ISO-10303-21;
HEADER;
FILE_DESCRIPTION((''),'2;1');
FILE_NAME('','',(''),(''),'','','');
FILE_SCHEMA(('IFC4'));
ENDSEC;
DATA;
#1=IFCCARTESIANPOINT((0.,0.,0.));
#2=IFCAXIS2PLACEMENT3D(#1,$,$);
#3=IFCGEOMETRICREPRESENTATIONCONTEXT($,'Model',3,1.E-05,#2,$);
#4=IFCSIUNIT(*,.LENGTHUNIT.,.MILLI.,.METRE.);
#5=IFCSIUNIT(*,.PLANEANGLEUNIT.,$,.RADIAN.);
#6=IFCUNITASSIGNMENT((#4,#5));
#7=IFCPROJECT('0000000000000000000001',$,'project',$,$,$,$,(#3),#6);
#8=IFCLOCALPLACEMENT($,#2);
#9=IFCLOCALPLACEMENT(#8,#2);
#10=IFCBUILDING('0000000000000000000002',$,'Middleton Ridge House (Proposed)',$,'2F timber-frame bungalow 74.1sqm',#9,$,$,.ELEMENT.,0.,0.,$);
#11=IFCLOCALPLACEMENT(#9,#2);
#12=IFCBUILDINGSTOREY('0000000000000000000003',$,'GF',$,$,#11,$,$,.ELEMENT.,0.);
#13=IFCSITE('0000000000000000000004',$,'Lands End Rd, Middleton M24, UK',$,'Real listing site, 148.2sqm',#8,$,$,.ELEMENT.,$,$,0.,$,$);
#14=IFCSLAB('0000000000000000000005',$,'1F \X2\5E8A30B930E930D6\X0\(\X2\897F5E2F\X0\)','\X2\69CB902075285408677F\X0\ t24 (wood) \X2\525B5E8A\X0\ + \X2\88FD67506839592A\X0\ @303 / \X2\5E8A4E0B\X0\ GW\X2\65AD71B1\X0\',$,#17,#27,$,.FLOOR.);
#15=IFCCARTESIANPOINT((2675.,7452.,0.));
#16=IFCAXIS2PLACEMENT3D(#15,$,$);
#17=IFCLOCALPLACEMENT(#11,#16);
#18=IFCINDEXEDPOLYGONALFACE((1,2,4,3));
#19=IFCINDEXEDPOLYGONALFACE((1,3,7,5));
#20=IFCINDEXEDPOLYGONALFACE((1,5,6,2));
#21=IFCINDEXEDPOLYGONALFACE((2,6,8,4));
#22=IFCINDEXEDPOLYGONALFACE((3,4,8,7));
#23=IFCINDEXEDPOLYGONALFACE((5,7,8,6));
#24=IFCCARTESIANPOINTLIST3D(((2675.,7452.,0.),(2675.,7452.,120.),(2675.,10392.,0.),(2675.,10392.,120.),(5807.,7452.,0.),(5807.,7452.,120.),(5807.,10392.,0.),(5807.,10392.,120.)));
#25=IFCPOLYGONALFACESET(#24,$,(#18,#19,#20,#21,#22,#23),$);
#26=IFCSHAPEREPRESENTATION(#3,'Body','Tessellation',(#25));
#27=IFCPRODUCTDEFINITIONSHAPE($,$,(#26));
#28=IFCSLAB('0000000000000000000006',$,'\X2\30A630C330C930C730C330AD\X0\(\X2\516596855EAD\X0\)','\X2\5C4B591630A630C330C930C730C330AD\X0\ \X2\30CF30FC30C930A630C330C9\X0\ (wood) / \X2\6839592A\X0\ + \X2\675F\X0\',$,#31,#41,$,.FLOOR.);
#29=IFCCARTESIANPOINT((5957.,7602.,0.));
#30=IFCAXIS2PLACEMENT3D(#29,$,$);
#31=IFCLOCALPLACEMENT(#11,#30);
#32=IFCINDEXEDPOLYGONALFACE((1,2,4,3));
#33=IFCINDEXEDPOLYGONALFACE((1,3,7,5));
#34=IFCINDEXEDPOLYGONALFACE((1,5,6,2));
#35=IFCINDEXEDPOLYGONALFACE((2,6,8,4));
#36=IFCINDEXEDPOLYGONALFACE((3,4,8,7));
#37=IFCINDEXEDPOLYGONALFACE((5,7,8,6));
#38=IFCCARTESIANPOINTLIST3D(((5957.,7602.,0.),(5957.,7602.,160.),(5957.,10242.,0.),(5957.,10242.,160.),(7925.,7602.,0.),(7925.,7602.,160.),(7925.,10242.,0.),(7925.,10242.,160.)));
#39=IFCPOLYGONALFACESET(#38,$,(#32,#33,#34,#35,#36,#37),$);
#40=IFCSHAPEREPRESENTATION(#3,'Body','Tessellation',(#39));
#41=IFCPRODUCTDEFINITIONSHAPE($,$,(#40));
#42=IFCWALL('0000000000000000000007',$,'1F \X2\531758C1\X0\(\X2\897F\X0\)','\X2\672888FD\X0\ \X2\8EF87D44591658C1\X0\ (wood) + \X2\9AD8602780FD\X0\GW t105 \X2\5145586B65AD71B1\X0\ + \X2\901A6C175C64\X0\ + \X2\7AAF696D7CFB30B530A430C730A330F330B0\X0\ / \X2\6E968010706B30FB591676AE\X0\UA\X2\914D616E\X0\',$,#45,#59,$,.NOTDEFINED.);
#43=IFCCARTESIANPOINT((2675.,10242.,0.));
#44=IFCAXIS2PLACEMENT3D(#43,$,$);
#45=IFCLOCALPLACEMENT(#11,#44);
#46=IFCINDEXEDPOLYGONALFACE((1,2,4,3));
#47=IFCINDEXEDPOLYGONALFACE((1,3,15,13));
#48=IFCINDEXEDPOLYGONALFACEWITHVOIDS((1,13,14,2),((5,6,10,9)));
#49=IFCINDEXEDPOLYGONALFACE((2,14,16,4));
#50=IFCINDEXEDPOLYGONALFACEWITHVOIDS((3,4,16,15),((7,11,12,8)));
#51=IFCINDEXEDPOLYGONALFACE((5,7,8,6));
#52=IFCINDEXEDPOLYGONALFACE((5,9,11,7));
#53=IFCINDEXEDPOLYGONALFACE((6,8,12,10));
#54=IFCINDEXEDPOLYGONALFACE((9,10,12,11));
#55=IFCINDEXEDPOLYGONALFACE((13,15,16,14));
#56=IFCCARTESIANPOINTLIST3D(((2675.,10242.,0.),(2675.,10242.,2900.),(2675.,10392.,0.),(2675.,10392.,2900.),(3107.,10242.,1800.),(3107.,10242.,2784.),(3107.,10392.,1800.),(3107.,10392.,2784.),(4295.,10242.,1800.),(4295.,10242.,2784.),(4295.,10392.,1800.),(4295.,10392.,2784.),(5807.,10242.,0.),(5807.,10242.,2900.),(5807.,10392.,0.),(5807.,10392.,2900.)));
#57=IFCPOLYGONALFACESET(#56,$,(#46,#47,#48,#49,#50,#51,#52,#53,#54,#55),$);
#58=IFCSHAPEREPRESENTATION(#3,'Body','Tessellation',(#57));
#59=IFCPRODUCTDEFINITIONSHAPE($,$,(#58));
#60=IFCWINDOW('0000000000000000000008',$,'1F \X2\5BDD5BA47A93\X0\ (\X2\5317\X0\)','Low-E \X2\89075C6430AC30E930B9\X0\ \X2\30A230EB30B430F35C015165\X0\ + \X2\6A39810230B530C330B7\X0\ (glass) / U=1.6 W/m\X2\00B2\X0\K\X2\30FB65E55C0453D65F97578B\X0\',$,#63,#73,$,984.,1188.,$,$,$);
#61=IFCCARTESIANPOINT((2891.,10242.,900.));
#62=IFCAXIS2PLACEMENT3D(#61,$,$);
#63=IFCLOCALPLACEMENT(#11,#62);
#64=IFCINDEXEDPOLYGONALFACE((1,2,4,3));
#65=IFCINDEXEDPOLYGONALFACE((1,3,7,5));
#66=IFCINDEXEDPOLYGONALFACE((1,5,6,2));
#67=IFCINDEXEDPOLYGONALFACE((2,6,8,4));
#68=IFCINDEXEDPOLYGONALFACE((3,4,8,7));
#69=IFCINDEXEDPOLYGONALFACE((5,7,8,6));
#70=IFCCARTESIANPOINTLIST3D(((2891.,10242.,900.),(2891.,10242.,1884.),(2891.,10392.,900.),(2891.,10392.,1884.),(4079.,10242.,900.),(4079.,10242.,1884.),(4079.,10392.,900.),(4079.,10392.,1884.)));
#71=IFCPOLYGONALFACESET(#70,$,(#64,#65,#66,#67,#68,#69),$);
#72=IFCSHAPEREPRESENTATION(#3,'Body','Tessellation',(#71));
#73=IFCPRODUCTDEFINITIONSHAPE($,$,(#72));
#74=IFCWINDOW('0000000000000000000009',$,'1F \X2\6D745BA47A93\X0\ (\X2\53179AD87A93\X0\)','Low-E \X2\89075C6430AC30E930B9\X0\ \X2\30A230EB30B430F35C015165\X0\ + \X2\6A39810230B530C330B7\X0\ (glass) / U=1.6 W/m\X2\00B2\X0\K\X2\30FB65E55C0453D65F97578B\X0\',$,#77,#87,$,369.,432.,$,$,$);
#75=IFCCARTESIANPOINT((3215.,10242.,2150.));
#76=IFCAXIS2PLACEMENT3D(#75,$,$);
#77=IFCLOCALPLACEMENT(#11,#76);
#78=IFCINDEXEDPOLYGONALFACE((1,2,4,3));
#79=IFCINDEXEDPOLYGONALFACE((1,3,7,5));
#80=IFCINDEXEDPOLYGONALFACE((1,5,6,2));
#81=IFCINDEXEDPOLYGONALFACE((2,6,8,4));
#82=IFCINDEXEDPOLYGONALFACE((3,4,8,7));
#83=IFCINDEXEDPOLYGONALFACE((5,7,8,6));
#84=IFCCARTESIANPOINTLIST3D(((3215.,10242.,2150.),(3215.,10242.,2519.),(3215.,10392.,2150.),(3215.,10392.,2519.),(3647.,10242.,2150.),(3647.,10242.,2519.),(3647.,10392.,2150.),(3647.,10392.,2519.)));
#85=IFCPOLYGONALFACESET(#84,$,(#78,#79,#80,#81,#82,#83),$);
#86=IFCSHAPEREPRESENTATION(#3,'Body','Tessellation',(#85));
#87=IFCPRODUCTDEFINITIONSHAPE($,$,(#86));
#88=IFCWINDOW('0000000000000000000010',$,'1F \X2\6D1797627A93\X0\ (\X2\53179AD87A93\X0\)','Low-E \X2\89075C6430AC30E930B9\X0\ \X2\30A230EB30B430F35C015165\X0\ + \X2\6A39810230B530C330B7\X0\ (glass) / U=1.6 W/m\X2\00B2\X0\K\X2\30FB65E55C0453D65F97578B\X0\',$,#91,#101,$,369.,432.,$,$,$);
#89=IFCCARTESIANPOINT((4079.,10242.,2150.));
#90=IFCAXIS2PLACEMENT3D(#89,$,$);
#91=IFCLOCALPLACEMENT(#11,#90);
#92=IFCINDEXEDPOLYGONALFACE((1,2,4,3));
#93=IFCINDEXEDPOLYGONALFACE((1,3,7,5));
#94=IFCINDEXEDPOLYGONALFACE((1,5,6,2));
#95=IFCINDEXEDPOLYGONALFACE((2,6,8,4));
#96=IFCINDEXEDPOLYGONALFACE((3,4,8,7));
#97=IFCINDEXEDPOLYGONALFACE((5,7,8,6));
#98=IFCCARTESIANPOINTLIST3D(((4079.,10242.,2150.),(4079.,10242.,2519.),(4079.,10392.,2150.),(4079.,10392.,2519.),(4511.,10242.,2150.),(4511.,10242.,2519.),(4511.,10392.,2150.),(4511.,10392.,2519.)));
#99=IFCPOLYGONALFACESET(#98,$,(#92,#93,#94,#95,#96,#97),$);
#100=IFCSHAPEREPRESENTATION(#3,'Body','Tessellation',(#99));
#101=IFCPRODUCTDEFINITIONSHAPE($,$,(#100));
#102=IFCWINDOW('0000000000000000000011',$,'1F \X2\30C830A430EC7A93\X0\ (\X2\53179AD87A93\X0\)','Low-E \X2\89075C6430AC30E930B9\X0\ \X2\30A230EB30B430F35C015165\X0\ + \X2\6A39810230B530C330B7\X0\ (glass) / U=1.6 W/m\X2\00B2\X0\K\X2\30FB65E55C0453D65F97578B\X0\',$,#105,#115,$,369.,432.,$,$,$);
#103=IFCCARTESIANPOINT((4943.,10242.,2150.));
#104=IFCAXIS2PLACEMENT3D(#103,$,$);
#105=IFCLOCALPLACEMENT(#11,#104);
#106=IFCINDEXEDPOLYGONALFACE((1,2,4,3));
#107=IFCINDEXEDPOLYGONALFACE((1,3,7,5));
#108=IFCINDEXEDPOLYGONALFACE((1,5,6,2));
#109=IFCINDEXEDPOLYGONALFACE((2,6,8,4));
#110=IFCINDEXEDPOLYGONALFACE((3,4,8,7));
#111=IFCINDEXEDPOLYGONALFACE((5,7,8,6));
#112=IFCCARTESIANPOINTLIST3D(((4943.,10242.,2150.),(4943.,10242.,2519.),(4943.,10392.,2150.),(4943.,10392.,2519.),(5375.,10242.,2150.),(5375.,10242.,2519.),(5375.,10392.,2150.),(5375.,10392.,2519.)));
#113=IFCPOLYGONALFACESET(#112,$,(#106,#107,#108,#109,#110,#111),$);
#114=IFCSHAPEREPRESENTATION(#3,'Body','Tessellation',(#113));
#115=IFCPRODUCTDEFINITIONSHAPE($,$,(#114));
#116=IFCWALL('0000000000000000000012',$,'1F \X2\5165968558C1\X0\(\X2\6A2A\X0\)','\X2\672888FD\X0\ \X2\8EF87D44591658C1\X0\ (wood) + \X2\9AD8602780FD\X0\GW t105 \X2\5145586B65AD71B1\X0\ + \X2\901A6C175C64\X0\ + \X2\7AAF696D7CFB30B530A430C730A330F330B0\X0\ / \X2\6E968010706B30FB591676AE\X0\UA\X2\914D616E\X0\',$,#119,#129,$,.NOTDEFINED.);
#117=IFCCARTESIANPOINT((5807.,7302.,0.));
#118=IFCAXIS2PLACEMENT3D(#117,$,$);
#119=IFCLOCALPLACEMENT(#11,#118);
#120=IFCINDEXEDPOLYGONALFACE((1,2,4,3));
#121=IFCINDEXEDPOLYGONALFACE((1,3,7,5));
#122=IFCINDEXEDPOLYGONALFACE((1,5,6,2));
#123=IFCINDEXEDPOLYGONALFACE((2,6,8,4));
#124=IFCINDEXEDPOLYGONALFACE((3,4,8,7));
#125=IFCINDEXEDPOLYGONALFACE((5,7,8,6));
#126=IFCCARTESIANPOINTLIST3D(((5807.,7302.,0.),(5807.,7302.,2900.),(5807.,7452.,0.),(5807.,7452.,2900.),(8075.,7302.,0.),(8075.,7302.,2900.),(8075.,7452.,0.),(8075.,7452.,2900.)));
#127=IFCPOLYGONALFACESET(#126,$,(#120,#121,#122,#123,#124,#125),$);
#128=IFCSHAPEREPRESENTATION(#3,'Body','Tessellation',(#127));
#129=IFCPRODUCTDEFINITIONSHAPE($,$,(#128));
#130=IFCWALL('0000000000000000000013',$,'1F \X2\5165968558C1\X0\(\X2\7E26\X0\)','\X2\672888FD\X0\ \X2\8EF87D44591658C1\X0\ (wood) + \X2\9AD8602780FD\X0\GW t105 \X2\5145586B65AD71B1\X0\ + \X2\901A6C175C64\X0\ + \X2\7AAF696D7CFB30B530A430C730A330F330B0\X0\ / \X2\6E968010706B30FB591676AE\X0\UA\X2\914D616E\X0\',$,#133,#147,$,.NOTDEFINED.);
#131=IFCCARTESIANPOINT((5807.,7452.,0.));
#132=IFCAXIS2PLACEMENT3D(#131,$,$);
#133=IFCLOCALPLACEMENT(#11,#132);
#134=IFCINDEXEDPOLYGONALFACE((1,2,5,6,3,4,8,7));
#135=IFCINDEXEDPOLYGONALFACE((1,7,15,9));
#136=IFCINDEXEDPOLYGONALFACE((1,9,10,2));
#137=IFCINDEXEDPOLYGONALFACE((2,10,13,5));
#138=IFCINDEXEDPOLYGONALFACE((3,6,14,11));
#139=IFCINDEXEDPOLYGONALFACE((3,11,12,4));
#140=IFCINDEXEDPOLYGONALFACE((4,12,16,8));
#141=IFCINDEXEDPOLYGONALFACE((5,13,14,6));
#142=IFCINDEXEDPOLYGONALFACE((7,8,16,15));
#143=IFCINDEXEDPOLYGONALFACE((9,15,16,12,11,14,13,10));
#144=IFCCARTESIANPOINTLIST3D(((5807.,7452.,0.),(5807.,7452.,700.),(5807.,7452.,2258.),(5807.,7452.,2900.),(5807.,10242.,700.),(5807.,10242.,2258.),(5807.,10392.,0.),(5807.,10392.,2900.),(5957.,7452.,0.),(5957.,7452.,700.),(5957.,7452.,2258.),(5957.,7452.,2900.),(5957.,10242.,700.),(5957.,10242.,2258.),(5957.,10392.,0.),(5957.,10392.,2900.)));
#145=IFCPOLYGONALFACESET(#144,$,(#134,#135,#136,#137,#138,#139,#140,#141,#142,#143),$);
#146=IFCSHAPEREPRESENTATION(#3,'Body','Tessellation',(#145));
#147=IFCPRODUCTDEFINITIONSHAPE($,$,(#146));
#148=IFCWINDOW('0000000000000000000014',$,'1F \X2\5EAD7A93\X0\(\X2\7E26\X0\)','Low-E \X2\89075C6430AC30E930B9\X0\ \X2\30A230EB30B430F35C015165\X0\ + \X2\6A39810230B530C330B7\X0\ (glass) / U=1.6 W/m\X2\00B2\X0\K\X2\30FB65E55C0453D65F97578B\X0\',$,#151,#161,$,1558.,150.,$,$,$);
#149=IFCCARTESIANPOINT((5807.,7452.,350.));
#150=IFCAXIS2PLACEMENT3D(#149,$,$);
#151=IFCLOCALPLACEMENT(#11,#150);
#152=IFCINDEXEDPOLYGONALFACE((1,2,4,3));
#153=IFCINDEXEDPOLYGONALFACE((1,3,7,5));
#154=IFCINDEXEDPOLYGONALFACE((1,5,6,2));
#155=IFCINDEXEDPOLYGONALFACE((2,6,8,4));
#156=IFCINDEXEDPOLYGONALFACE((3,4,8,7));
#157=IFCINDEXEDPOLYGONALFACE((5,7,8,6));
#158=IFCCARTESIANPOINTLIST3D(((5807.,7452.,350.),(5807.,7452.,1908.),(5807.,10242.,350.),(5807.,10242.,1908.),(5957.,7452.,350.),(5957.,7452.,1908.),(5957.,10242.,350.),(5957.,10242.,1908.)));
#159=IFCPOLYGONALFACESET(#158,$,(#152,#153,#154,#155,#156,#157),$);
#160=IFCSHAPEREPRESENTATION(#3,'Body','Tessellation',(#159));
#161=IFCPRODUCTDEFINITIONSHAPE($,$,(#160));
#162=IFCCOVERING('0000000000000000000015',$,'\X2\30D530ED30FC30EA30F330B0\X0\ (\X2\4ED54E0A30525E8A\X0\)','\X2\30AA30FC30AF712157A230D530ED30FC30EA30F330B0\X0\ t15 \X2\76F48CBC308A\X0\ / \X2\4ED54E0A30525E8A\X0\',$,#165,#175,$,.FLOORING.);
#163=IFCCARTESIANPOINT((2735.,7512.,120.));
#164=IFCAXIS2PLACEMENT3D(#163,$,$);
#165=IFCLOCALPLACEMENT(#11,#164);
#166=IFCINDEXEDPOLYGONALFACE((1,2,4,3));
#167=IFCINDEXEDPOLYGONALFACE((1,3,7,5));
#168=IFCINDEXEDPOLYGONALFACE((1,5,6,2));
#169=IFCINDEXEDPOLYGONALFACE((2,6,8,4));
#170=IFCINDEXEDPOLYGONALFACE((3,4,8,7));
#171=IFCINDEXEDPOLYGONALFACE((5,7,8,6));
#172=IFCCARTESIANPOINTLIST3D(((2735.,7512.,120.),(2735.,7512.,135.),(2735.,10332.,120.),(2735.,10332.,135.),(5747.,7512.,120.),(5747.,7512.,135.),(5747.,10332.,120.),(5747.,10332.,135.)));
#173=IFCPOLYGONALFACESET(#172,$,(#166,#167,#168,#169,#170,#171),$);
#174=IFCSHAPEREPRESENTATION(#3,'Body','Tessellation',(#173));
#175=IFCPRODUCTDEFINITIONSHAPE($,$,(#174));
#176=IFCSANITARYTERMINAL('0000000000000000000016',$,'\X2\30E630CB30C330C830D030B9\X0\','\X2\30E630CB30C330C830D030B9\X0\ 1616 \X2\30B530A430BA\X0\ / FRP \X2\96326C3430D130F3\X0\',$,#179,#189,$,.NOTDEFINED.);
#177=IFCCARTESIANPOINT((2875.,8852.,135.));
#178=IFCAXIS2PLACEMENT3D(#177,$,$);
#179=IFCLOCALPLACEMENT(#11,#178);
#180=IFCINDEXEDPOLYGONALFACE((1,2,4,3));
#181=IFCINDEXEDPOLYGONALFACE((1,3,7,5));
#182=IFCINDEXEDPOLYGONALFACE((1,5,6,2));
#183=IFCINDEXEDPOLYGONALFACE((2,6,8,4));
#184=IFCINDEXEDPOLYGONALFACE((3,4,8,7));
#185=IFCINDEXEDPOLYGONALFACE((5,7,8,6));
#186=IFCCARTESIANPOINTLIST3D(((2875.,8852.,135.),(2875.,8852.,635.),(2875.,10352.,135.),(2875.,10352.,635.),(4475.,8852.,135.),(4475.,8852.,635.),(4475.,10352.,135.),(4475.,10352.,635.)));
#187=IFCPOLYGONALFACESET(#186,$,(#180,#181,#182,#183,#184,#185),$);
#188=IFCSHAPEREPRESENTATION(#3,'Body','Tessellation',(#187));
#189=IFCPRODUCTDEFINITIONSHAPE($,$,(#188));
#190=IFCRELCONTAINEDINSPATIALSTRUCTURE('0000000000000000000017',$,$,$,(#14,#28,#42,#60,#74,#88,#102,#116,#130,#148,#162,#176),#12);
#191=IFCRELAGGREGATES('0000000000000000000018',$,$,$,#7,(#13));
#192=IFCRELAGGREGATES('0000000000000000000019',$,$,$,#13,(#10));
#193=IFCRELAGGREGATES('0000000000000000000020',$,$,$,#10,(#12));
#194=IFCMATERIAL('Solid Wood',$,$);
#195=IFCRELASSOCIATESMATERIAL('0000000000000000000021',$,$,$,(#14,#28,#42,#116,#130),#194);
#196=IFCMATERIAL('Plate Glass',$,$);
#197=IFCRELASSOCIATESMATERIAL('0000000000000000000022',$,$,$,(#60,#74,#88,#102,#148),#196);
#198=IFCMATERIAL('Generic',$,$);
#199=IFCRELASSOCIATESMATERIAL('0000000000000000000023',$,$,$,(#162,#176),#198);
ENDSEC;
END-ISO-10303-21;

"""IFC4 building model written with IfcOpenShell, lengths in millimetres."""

from ifc_helpers import new_model, si_unit, frame, frame_2d, origin, place, context, project, spatial, rectangle, extrude, material, element, fill, save


model = new_model("IFC4")

# Units and contexts
model_context = context("Model", 3, precision=1e-05, world=origin())
ifc_project = project(units=[si_unit("LENGTHUNIT", "METRE", prefix="MILLI"), si_unit("PLANEANGLEUNIT", "RADIAN")], contexts=[model_context])

# Site, building, storey
site_placement = place(None, origin())
site = spatial("IfcSite", under=ifc_project, at=site_placement, Name="Lands End Rd, Middleton M24, UK", ObjectType="Real listing site, 148.2sqm", CompositionType="ELEMENT", RefElevation=0.0)
building_placement = place(site_placement, origin())
building = spatial("IfcBuilding", under=site, at=building_placement, Name="Middleton Ridge House (Proposed)", ObjectType="2F timber-frame bungalow 74.1sqm", CompositionType="ELEMENT", ElevationOfRefHeight=0.0, ElevationOfTerrain=0.0)
storey_placement = place(building_placement, origin())
storey = spatial("IfcBuildingStorey", under=building, at=storey_placement, Name="GF", CompositionType="ELEMENT", Elevation=0.0)

# Slabs
ifc_material_1 = material(Name="Solid Wood")
slab_1_placement = place(storey_placement, frame((2675.0, 7452.0, 0.0)))
element("IfcSlab", 1, at=slab_1_placement, inside=storey, material=ifc_material_1, Name="1F 床スラブ(西帯)", Description="構造用合板 t24 (wood) 剛床 + 製材根太 @303 / 床下 GW断熱", PredefinedType="FLOOR", context=model_context, shape_type="SweptSolid", body=[
    extrude(rectangle(XDim=3132.0, YDim=2940.0, at=frame_2d((1566.0, 1470.0))), frame((2675.0, 7452.0, 0.0)), (0.0, 0.0, 1.0), 120.0),
])
slab_2_placement = place(storey_placement, frame((5957.0, 7602.0, 0.0)))
element("IfcSlab", 2, at=slab_2_placement, inside=storey, material=ifc_material_1, Name="ウッドデッキ(入隅庭)", Description="屋外ウッドデッキ ハードウッド (wood) / 根太 + 束", PredefinedType="FLOOR", context=model_context, shape_type="SweptSolid", body=[
    extrude(rectangle(XDim=1968.0, YDim=2640.0, at=frame_2d((984.0, 1320.0))), frame((5957.0, 7602.0, 0.0)), (0.0, 0.0, 1.0), 160.0),
])

# Wall, openings, windows
wall_1_placement = place(storey_placement, frame((2675.0, 10242.0, 0.0)))
wall_1 = element("IfcWall", 3, at=wall_1_placement, inside=storey, material=ifc_material_1, Name="1F 北壁(西)", Description="木製 軸組外壁 (wood) + 高性能GW t105 充填断熱 + 通気層 + 窯業系サイディング / 準耐火・外皮UA配慮", PredefinedType="NOTDEFINED", context=model_context, shape_type="SweptSolid", body=[
    extrude(rectangle(XDim=3132.0, YDim=150.0, at=frame_2d((1566.0, 75.0))), frame((2675.0, 10242.0, 0.0)), (0.0, 0.0, 1.0), 2900.0),
])
opening_1_placement = place(storey_placement, frame((2891.0, 10242.0, 900.0)))
opening_1 = element("IfcOpeningElement", 4, at=opening_1_placement, cuts=wall_1, PredefinedType="NOTDEFINED", context=model_context, shape_type="SweptSolid", body=[
    extrude(rectangle(XDim=1188.0, YDim=150.0, at=frame_2d((594.0, 75.0))), frame((2891.0, 10242.0, 900.0)), (0.0, 0.0, 1.0), 984.0),
])
opening_2_placement = place(storey_placement, frame((3215.0, 10242.0, 2150.0)))
opening_2 = element("IfcOpeningElement", 5, at=opening_2_placement, cuts=wall_1, PredefinedType="NOTDEFINED", context=model_context, shape_type="SweptSolid", body=[
    extrude(rectangle(XDim=432.0, YDim=150.0, at=frame_2d((216.0, 75.0))), frame((3215.0, 10242.0, 2150.0)), (0.0, 0.0, 1.0), 369.0),
])
opening_3_placement = place(storey_placement, frame((4079.0, 10242.0, 2150.0)))
opening_3 = element("IfcOpeningElement", 6, at=opening_3_placement, cuts=wall_1, PredefinedType="NOTDEFINED", context=model_context, shape_type="SweptSolid", body=[
    extrude(rectangle(XDim=432.0, YDim=150.0, at=frame_2d((216.0, 75.0))), frame((4079.0, 10242.0, 2150.0)), (0.0, 0.0, 1.0), 369.0),
])
opening_4_placement = place(storey_placement, frame((4943.0, 10242.0, 2150.0)))
opening_4 = element("IfcOpeningElement", 7, at=opening_4_placement, cuts=wall_1, PredefinedType="NOTDEFINED", context=model_context, shape_type="SweptSolid", body=[
    extrude(rectangle(XDim=432.0, YDim=150.0, at=frame_2d((216.0, 75.0))), frame((4943.0, 10242.0, 2150.0)), (0.0, 0.0, 1.0), 369.0),
])
ifc_material_2 = material(Name="Plate Glass")
window_1_placement = place(storey_placement, frame((2891.0, 10242.0, 900.0)))
window_1 = element("IfcWindow", 8, at=window_1_placement, inside=storey, material=ifc_material_2, Name="1F 寝室窓 (北)", Description="Low-E 複層ガラス アルゴン封入 + 樹脂サッシ (glass) / U=1.6 W/m²K・日射取得型", OverallHeight=984.0, OverallWidth=1188.0, context=model_context, shape_type="SweptSolid", body=[
    extrude(rectangle(XDim=1188.0, YDim=150.0, at=frame_2d((594.0, 75.0))), frame((2891.0, 10242.0, 900.0)), (0.0, 0.0, 1.0), 984.0),
])
fill(opening_1, window_1)
window_2_placement = place(storey_placement, frame((3215.0, 10242.0, 2150.0)))
window_2 = element("IfcWindow", 9, at=window_2_placement, inside=storey, material=ifc_material_2, Name="1F 浴室窓 (北高窓)", Description="Low-E 複層ガラス アルゴン封入 + 樹脂サッシ (glass) / U=1.6 W/m²K・日射取得型", OverallHeight=369.0, OverallWidth=432.0, context=model_context, shape_type="SweptSolid", body=[
    extrude(rectangle(XDim=432.0, YDim=150.0, at=frame_2d((216.0, 75.0))), frame((3215.0, 10242.0, 2150.0)), (0.0, 0.0, 1.0), 369.0),
])
fill(opening_2, window_2)
window_3_placement = place(storey_placement, frame((4079.0, 10242.0, 2150.0)))
window_3 = element("IfcWindow", 10, at=window_3_placement, inside=storey, material=ifc_material_2, Name="1F 洗面窓 (北高窓)", Description="Low-E 複層ガラス アルゴン封入 + 樹脂サッシ (glass) / U=1.6 W/m²K・日射取得型", OverallHeight=369.0, OverallWidth=432.0, context=model_context, shape_type="SweptSolid", body=[
    extrude(rectangle(XDim=432.0, YDim=150.0, at=frame_2d((216.0, 75.0))), frame((4079.0, 10242.0, 2150.0)), (0.0, 0.0, 1.0), 369.0),
])
fill(opening_3, window_3)
window_4_placement = place(storey_placement, frame((4943.0, 10242.0, 2150.0)))
window_4 = element("IfcWindow", 11, at=window_4_placement, inside=storey, material=ifc_material_2, Name="1F トイレ窓 (北高窓)", Description="Low-E 複層ガラス アルゴン封入 + 樹脂サッシ (glass) / U=1.6 W/m²K・日射取得型", OverallHeight=369.0, OverallWidth=432.0, context=model_context, shape_type="SweptSolid", body=[
    extrude(rectangle(XDim=432.0, YDim=150.0, at=frame_2d((216.0, 75.0))), frame((4943.0, 10242.0, 2150.0)), (0.0, 0.0, 1.0), 369.0),
])
fill(opening_4, window_4)

# Wall
wall_2_placement = place(storey_placement, frame((5807.0, 7302.0, 0.0)))
element("IfcWall", 12, at=wall_2_placement, inside=storey, material=ifc_material_1, Name="1F 入隅壁(横)", Description="木製 軸組外壁 (wood) + 高性能GW t105 充填断熱 + 通気層 + 窯業系サイディング / 準耐火・外皮UA配慮", PredefinedType="NOTDEFINED", context=model_context, shape_type="SweptSolid", body=[
    extrude(rectangle(XDim=2268.0, YDim=150.0, at=frame_2d((1134.0, 75.0))), frame((5807.0, 7302.0, 0.0)), (0.0, 0.0, 1.0), 2900.0),
])

# Wall, opening, window
wall_3_placement = place(storey_placement, frame((5807.0, 7452.0, 0.0)))
wall_3 = element("IfcWall", 13, at=wall_3_placement, inside=storey, material=ifc_material_1, Name="1F 入隅壁(縦)", Description="木製 軸組外壁 (wood) + 高性能GW t105 充填断熱 + 通気層 + 窯業系サイディング / 準耐火・外皮UA配慮", PredefinedType="NOTDEFINED", context=model_context, shape_type="SweptSolid", body=[
    extrude(rectangle(XDim=150.0, YDim=2940.0, at=frame_2d((75.0, 1470.0))), frame((5807.0, 7452.0, 0.0)), (0.0, 0.0, 1.0), 2900.0),
])
opening_5_placement = place(storey_placement, frame((5807.0, 7452.0, 350.0)))
opening_5 = element("IfcOpeningElement", 14, at=opening_5_placement, cuts=wall_3, PredefinedType="NOTDEFINED", context=model_context, shape_type="SweptSolid", body=[
    extrude(rectangle(XDim=150.0, YDim=2790.0, at=frame_2d((75.0, 1395.0))), frame((5807.0, 7452.0, 350.0)), (0.0, 0.0, 1.0), 1558.0),
])
window_5_placement = place(storey_placement, frame((5807.0, 7452.0, 350.0)))
window_5 = element("IfcWindow", 15, at=window_5_placement, inside=storey, material=ifc_material_2, Name="1F 庭窓(縦)", Description="Low-E 複層ガラス アルゴン封入 + 樹脂サッシ (glass) / U=1.6 W/m²K・日射取得型", OverallHeight=1558.0, OverallWidth=150.0, context=model_context, shape_type="SweptSolid", body=[
    extrude(rectangle(XDim=150.0, YDim=2790.0, at=frame_2d((75.0, 1395.0))), frame((5807.0, 7452.0, 350.0)), (0.0, 0.0, 1.0), 1558.0),
])
fill(opening_5, window_5)

# Covering
ifc_material_3 = material(Name="Generic")
covering_placement = place(storey_placement, frame((2735.0, 7512.0, 120.0)))
element("IfcCovering", 16, at=covering_placement, inside=storey, material=ifc_material_3, Name="フローリング (仕上げ床)", Description="オーク無垢フローリング t15 直貼り / 仕上げ床", PredefinedType="FLOORING", context=model_context, shape_type="SweptSolid", body=[
    extrude(rectangle(XDim=3012.0, YDim=2820.0, at=frame_2d((1506.0, 1410.0))), frame((2735.0, 7512.0, 120.0)), (0.0, 0.0, 1.0), 15.0),
])

# Sanitary terminal
sanitary_terminal_1_placement = place(storey_placement, frame((2875.0, 8852.0, 135.0)))
element("IfcSanitaryTerminal", 17, at=sanitary_terminal_1_placement, inside=storey, material=ifc_material_3, Name="ユニットバス", Description="ユニットバス 1616 サイズ / FRP 防水パン", PredefinedType="NOTDEFINED", context=model_context, shape_type="SweptSolid", body=[
    extrude(rectangle(XDim=1600.0, YDim=1500.0, at=frame_2d((800.0, 750.0))), frame((2875.0, 8852.0, 135.0)), (0.0, 0.0, 1.0), 500.0),
])

save(model, "model.ifc")
